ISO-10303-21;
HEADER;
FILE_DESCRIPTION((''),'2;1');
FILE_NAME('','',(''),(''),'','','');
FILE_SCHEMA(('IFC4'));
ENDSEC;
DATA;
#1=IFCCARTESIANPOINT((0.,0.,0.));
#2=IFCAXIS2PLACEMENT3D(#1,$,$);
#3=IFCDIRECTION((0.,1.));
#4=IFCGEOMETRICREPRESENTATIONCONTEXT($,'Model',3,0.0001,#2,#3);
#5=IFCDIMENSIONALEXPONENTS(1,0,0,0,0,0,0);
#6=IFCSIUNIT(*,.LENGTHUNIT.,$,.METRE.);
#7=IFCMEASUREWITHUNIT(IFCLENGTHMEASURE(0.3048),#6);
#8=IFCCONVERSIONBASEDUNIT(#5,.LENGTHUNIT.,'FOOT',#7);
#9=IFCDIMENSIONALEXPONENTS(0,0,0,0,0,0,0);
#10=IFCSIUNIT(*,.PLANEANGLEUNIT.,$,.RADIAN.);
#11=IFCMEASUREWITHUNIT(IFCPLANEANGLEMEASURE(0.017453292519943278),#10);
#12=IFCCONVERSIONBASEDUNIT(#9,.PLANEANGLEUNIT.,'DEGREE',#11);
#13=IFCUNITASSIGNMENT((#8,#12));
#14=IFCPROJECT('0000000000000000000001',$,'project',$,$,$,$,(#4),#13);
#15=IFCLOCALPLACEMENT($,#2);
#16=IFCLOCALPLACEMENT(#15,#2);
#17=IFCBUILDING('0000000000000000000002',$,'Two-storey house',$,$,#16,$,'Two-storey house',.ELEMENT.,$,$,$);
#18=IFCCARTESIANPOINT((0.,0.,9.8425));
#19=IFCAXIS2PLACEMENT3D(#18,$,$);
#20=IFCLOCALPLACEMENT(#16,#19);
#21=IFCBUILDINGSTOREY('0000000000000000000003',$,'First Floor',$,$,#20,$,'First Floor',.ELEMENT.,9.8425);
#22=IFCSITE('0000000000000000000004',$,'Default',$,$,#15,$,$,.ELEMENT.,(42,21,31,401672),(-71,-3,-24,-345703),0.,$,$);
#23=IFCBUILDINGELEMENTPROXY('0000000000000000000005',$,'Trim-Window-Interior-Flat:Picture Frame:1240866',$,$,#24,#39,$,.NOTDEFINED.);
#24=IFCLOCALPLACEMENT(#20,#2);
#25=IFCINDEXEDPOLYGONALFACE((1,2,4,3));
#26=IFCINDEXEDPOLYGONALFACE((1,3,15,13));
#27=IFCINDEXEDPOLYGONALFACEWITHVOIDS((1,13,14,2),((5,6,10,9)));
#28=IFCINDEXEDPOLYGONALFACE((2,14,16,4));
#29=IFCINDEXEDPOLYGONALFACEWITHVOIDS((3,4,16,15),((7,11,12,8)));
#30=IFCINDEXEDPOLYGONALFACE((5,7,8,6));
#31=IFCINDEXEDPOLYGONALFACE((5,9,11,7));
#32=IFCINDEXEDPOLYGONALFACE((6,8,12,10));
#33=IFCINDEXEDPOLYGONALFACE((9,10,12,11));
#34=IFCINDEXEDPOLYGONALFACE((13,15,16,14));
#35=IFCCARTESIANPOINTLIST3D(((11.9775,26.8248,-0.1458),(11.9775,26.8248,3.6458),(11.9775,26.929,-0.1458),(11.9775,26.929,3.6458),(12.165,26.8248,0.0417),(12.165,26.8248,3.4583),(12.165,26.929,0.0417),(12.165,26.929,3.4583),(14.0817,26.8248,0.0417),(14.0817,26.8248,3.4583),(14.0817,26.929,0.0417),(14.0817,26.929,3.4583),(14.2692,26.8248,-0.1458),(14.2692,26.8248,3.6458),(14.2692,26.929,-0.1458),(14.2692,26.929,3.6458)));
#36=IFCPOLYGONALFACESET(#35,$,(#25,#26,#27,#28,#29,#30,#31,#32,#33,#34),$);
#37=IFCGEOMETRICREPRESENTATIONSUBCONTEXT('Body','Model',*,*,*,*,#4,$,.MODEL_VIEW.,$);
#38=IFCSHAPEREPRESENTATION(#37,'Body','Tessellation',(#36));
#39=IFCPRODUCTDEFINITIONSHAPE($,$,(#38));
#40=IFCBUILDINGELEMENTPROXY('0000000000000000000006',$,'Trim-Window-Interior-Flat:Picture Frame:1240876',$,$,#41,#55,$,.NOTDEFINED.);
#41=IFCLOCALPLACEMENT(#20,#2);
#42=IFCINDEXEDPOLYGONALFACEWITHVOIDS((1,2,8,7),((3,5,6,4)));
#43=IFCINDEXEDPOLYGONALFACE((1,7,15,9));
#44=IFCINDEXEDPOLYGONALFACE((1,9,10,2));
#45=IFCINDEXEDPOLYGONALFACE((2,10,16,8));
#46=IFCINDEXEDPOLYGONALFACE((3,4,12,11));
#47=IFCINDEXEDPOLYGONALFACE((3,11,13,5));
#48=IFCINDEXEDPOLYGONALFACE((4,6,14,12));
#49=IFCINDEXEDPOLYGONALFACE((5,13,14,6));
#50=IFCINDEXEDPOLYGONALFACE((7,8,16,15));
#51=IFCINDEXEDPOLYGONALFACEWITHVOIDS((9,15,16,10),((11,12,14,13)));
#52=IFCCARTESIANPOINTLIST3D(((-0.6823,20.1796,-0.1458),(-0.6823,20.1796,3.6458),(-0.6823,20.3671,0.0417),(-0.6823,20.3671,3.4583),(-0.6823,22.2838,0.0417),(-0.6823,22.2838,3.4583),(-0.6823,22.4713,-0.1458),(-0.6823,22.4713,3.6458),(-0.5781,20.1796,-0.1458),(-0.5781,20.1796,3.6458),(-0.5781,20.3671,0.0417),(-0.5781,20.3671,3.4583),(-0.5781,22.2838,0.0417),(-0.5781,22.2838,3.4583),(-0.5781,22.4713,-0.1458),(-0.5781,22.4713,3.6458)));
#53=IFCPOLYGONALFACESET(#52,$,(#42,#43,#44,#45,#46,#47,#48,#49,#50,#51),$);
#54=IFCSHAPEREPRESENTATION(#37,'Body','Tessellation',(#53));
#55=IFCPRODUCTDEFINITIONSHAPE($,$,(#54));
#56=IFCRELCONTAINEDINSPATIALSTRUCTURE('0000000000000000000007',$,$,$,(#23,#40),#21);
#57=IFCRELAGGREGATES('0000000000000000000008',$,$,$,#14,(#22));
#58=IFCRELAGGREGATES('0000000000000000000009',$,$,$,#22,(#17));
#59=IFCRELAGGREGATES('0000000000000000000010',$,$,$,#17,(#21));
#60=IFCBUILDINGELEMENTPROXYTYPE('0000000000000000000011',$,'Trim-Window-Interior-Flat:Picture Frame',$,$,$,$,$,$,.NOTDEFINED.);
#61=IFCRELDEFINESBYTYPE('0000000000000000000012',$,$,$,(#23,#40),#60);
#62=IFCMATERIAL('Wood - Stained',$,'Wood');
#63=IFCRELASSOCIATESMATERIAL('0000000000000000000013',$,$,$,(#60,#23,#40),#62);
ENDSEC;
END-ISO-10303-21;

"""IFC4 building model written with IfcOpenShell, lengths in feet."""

from ifc_helpers import new_model, entity, si_unit, converted_unit, direction, frame, origin, place, context, subcontext, project, spatial, indexed_curve, outline, extrude, source, transform, mapped, material, type_object, type_shapes, element, save


model = new_model("IFC4")

# Units and contexts
model_context = context("Model", 3, precision=0.0001, world=origin(), true_north=direction((0.0, 1.0)))
body_context = subcontext(model_context, "Body", "Model", "MODEL_VIEW")
ifc_project = project(units=[converted_unit("LENGTHUNIT", "FOOT", entity("IfcLengthMeasure", 0.3048), si_unit("LENGTHUNIT", "METRE"), dimensions=[1, 0, 0, 0, 0, 0, 0]), converted_unit("PLANEANGLEUNIT", "DEGREE", entity("IfcPlaneAngleMeasure", 0.017453292519943278), si_unit("PLANEANGLEUNIT", "RADIAN"), dimensions=[0, 0, 0, 0, 0, 0, 0])], contexts=[model_context])

# Site, building, storey
site_placement = place(None, origin())
site = spatial("IfcSite", under=ifc_project, at=site_placement, Name="Default", CompositionType="ELEMENT", RefLatitude=(42, 21, 31, 401672), RefLongitude=(-71, -3, -24, -345703), RefElevation=0.0)
building_placement = place(site_placement, origin())
building = spatial("IfcBuilding", under=site, at=building_placement, Name="Two-storey house", LongName="Two-storey house", CompositionType="ELEMENT")
storey_placement = place(building_placement, frame((0.0, 0.0, 9.8425)))
storey = spatial("IfcBuildingStorey", under=building, at=storey_placement, Name="First Floor", LongName="First Floor", CompositionType="ELEMENT", Elevation=9.8425)

# Shared definitions
ifc_material_1 = material(Name="Wood - Stained", Category="Wood")

# Building element proxies
building_element_proxy_type_1 = type_object("IfcBuildingElementProxyType", Name="Trim-Window-Interior-Flat:Picture Frame", PredefinedType="NOTDEFINED", material=ifc_material_1)
shared_shape_1 = source(origin(), body_context, "Body", "SweptSolid", [
    extrude(outline(indexed_curve([(-1.1458, -1.8958), (1.1458, -1.8958), (1.1458, 1.8958), (-1.1458, 1.8958), (-1.1458, -1.8958)], self_intersect=False), holes=[indexed_curve([(-0.9583, -1.7083), (-0.9583, 1.7083), (0.9583, 1.7083), (0.9583, -1.7083), (-0.9583, -1.7083)], self_intersect=False)]), frame((0.0, -1.75, 0.0), z_axis=(0.0, 0.0, 1.0), x_axis=(-1.0, 0.0, 0.0)), (0.0, 0.0, 1.0), 0.1042),
])
type_shapes(building_element_proxy_type_1, [shared_shape_1])
for number, where, z_axis, x_axis, name in (
    (1, (13.1234, 26.8248, 3.5), (0.0, 1.0, 0.0), (-1.0, 0.0, 0.0), "Trim-Window-Interior-Flat:Picture Frame:1240866"),
    (2, (-0.5781, 21.3255, 3.5), (-1.0, 0.0, 0.0), (0.0, -1.0, 0.0), "Trim-Window-Interior-Flat:Picture Frame:1240876"),
):
    element("IfcBuildingElementProxy", number, at=place(storey_placement, frame(where, z_axis=z_axis, x_axis=x_axis)), inside=storey, type_object=building_element_proxy_type_1, material=ifc_material_1, Name=name, PredefinedType="NOTDEFINED", context=body_context, shape_type="MappedRepresentation", body=[
        mapped(shared_shape_1, transform((0.0, 0.0, 0.0), scale=1.0)),
    ])

save(model, "model.ifc")
